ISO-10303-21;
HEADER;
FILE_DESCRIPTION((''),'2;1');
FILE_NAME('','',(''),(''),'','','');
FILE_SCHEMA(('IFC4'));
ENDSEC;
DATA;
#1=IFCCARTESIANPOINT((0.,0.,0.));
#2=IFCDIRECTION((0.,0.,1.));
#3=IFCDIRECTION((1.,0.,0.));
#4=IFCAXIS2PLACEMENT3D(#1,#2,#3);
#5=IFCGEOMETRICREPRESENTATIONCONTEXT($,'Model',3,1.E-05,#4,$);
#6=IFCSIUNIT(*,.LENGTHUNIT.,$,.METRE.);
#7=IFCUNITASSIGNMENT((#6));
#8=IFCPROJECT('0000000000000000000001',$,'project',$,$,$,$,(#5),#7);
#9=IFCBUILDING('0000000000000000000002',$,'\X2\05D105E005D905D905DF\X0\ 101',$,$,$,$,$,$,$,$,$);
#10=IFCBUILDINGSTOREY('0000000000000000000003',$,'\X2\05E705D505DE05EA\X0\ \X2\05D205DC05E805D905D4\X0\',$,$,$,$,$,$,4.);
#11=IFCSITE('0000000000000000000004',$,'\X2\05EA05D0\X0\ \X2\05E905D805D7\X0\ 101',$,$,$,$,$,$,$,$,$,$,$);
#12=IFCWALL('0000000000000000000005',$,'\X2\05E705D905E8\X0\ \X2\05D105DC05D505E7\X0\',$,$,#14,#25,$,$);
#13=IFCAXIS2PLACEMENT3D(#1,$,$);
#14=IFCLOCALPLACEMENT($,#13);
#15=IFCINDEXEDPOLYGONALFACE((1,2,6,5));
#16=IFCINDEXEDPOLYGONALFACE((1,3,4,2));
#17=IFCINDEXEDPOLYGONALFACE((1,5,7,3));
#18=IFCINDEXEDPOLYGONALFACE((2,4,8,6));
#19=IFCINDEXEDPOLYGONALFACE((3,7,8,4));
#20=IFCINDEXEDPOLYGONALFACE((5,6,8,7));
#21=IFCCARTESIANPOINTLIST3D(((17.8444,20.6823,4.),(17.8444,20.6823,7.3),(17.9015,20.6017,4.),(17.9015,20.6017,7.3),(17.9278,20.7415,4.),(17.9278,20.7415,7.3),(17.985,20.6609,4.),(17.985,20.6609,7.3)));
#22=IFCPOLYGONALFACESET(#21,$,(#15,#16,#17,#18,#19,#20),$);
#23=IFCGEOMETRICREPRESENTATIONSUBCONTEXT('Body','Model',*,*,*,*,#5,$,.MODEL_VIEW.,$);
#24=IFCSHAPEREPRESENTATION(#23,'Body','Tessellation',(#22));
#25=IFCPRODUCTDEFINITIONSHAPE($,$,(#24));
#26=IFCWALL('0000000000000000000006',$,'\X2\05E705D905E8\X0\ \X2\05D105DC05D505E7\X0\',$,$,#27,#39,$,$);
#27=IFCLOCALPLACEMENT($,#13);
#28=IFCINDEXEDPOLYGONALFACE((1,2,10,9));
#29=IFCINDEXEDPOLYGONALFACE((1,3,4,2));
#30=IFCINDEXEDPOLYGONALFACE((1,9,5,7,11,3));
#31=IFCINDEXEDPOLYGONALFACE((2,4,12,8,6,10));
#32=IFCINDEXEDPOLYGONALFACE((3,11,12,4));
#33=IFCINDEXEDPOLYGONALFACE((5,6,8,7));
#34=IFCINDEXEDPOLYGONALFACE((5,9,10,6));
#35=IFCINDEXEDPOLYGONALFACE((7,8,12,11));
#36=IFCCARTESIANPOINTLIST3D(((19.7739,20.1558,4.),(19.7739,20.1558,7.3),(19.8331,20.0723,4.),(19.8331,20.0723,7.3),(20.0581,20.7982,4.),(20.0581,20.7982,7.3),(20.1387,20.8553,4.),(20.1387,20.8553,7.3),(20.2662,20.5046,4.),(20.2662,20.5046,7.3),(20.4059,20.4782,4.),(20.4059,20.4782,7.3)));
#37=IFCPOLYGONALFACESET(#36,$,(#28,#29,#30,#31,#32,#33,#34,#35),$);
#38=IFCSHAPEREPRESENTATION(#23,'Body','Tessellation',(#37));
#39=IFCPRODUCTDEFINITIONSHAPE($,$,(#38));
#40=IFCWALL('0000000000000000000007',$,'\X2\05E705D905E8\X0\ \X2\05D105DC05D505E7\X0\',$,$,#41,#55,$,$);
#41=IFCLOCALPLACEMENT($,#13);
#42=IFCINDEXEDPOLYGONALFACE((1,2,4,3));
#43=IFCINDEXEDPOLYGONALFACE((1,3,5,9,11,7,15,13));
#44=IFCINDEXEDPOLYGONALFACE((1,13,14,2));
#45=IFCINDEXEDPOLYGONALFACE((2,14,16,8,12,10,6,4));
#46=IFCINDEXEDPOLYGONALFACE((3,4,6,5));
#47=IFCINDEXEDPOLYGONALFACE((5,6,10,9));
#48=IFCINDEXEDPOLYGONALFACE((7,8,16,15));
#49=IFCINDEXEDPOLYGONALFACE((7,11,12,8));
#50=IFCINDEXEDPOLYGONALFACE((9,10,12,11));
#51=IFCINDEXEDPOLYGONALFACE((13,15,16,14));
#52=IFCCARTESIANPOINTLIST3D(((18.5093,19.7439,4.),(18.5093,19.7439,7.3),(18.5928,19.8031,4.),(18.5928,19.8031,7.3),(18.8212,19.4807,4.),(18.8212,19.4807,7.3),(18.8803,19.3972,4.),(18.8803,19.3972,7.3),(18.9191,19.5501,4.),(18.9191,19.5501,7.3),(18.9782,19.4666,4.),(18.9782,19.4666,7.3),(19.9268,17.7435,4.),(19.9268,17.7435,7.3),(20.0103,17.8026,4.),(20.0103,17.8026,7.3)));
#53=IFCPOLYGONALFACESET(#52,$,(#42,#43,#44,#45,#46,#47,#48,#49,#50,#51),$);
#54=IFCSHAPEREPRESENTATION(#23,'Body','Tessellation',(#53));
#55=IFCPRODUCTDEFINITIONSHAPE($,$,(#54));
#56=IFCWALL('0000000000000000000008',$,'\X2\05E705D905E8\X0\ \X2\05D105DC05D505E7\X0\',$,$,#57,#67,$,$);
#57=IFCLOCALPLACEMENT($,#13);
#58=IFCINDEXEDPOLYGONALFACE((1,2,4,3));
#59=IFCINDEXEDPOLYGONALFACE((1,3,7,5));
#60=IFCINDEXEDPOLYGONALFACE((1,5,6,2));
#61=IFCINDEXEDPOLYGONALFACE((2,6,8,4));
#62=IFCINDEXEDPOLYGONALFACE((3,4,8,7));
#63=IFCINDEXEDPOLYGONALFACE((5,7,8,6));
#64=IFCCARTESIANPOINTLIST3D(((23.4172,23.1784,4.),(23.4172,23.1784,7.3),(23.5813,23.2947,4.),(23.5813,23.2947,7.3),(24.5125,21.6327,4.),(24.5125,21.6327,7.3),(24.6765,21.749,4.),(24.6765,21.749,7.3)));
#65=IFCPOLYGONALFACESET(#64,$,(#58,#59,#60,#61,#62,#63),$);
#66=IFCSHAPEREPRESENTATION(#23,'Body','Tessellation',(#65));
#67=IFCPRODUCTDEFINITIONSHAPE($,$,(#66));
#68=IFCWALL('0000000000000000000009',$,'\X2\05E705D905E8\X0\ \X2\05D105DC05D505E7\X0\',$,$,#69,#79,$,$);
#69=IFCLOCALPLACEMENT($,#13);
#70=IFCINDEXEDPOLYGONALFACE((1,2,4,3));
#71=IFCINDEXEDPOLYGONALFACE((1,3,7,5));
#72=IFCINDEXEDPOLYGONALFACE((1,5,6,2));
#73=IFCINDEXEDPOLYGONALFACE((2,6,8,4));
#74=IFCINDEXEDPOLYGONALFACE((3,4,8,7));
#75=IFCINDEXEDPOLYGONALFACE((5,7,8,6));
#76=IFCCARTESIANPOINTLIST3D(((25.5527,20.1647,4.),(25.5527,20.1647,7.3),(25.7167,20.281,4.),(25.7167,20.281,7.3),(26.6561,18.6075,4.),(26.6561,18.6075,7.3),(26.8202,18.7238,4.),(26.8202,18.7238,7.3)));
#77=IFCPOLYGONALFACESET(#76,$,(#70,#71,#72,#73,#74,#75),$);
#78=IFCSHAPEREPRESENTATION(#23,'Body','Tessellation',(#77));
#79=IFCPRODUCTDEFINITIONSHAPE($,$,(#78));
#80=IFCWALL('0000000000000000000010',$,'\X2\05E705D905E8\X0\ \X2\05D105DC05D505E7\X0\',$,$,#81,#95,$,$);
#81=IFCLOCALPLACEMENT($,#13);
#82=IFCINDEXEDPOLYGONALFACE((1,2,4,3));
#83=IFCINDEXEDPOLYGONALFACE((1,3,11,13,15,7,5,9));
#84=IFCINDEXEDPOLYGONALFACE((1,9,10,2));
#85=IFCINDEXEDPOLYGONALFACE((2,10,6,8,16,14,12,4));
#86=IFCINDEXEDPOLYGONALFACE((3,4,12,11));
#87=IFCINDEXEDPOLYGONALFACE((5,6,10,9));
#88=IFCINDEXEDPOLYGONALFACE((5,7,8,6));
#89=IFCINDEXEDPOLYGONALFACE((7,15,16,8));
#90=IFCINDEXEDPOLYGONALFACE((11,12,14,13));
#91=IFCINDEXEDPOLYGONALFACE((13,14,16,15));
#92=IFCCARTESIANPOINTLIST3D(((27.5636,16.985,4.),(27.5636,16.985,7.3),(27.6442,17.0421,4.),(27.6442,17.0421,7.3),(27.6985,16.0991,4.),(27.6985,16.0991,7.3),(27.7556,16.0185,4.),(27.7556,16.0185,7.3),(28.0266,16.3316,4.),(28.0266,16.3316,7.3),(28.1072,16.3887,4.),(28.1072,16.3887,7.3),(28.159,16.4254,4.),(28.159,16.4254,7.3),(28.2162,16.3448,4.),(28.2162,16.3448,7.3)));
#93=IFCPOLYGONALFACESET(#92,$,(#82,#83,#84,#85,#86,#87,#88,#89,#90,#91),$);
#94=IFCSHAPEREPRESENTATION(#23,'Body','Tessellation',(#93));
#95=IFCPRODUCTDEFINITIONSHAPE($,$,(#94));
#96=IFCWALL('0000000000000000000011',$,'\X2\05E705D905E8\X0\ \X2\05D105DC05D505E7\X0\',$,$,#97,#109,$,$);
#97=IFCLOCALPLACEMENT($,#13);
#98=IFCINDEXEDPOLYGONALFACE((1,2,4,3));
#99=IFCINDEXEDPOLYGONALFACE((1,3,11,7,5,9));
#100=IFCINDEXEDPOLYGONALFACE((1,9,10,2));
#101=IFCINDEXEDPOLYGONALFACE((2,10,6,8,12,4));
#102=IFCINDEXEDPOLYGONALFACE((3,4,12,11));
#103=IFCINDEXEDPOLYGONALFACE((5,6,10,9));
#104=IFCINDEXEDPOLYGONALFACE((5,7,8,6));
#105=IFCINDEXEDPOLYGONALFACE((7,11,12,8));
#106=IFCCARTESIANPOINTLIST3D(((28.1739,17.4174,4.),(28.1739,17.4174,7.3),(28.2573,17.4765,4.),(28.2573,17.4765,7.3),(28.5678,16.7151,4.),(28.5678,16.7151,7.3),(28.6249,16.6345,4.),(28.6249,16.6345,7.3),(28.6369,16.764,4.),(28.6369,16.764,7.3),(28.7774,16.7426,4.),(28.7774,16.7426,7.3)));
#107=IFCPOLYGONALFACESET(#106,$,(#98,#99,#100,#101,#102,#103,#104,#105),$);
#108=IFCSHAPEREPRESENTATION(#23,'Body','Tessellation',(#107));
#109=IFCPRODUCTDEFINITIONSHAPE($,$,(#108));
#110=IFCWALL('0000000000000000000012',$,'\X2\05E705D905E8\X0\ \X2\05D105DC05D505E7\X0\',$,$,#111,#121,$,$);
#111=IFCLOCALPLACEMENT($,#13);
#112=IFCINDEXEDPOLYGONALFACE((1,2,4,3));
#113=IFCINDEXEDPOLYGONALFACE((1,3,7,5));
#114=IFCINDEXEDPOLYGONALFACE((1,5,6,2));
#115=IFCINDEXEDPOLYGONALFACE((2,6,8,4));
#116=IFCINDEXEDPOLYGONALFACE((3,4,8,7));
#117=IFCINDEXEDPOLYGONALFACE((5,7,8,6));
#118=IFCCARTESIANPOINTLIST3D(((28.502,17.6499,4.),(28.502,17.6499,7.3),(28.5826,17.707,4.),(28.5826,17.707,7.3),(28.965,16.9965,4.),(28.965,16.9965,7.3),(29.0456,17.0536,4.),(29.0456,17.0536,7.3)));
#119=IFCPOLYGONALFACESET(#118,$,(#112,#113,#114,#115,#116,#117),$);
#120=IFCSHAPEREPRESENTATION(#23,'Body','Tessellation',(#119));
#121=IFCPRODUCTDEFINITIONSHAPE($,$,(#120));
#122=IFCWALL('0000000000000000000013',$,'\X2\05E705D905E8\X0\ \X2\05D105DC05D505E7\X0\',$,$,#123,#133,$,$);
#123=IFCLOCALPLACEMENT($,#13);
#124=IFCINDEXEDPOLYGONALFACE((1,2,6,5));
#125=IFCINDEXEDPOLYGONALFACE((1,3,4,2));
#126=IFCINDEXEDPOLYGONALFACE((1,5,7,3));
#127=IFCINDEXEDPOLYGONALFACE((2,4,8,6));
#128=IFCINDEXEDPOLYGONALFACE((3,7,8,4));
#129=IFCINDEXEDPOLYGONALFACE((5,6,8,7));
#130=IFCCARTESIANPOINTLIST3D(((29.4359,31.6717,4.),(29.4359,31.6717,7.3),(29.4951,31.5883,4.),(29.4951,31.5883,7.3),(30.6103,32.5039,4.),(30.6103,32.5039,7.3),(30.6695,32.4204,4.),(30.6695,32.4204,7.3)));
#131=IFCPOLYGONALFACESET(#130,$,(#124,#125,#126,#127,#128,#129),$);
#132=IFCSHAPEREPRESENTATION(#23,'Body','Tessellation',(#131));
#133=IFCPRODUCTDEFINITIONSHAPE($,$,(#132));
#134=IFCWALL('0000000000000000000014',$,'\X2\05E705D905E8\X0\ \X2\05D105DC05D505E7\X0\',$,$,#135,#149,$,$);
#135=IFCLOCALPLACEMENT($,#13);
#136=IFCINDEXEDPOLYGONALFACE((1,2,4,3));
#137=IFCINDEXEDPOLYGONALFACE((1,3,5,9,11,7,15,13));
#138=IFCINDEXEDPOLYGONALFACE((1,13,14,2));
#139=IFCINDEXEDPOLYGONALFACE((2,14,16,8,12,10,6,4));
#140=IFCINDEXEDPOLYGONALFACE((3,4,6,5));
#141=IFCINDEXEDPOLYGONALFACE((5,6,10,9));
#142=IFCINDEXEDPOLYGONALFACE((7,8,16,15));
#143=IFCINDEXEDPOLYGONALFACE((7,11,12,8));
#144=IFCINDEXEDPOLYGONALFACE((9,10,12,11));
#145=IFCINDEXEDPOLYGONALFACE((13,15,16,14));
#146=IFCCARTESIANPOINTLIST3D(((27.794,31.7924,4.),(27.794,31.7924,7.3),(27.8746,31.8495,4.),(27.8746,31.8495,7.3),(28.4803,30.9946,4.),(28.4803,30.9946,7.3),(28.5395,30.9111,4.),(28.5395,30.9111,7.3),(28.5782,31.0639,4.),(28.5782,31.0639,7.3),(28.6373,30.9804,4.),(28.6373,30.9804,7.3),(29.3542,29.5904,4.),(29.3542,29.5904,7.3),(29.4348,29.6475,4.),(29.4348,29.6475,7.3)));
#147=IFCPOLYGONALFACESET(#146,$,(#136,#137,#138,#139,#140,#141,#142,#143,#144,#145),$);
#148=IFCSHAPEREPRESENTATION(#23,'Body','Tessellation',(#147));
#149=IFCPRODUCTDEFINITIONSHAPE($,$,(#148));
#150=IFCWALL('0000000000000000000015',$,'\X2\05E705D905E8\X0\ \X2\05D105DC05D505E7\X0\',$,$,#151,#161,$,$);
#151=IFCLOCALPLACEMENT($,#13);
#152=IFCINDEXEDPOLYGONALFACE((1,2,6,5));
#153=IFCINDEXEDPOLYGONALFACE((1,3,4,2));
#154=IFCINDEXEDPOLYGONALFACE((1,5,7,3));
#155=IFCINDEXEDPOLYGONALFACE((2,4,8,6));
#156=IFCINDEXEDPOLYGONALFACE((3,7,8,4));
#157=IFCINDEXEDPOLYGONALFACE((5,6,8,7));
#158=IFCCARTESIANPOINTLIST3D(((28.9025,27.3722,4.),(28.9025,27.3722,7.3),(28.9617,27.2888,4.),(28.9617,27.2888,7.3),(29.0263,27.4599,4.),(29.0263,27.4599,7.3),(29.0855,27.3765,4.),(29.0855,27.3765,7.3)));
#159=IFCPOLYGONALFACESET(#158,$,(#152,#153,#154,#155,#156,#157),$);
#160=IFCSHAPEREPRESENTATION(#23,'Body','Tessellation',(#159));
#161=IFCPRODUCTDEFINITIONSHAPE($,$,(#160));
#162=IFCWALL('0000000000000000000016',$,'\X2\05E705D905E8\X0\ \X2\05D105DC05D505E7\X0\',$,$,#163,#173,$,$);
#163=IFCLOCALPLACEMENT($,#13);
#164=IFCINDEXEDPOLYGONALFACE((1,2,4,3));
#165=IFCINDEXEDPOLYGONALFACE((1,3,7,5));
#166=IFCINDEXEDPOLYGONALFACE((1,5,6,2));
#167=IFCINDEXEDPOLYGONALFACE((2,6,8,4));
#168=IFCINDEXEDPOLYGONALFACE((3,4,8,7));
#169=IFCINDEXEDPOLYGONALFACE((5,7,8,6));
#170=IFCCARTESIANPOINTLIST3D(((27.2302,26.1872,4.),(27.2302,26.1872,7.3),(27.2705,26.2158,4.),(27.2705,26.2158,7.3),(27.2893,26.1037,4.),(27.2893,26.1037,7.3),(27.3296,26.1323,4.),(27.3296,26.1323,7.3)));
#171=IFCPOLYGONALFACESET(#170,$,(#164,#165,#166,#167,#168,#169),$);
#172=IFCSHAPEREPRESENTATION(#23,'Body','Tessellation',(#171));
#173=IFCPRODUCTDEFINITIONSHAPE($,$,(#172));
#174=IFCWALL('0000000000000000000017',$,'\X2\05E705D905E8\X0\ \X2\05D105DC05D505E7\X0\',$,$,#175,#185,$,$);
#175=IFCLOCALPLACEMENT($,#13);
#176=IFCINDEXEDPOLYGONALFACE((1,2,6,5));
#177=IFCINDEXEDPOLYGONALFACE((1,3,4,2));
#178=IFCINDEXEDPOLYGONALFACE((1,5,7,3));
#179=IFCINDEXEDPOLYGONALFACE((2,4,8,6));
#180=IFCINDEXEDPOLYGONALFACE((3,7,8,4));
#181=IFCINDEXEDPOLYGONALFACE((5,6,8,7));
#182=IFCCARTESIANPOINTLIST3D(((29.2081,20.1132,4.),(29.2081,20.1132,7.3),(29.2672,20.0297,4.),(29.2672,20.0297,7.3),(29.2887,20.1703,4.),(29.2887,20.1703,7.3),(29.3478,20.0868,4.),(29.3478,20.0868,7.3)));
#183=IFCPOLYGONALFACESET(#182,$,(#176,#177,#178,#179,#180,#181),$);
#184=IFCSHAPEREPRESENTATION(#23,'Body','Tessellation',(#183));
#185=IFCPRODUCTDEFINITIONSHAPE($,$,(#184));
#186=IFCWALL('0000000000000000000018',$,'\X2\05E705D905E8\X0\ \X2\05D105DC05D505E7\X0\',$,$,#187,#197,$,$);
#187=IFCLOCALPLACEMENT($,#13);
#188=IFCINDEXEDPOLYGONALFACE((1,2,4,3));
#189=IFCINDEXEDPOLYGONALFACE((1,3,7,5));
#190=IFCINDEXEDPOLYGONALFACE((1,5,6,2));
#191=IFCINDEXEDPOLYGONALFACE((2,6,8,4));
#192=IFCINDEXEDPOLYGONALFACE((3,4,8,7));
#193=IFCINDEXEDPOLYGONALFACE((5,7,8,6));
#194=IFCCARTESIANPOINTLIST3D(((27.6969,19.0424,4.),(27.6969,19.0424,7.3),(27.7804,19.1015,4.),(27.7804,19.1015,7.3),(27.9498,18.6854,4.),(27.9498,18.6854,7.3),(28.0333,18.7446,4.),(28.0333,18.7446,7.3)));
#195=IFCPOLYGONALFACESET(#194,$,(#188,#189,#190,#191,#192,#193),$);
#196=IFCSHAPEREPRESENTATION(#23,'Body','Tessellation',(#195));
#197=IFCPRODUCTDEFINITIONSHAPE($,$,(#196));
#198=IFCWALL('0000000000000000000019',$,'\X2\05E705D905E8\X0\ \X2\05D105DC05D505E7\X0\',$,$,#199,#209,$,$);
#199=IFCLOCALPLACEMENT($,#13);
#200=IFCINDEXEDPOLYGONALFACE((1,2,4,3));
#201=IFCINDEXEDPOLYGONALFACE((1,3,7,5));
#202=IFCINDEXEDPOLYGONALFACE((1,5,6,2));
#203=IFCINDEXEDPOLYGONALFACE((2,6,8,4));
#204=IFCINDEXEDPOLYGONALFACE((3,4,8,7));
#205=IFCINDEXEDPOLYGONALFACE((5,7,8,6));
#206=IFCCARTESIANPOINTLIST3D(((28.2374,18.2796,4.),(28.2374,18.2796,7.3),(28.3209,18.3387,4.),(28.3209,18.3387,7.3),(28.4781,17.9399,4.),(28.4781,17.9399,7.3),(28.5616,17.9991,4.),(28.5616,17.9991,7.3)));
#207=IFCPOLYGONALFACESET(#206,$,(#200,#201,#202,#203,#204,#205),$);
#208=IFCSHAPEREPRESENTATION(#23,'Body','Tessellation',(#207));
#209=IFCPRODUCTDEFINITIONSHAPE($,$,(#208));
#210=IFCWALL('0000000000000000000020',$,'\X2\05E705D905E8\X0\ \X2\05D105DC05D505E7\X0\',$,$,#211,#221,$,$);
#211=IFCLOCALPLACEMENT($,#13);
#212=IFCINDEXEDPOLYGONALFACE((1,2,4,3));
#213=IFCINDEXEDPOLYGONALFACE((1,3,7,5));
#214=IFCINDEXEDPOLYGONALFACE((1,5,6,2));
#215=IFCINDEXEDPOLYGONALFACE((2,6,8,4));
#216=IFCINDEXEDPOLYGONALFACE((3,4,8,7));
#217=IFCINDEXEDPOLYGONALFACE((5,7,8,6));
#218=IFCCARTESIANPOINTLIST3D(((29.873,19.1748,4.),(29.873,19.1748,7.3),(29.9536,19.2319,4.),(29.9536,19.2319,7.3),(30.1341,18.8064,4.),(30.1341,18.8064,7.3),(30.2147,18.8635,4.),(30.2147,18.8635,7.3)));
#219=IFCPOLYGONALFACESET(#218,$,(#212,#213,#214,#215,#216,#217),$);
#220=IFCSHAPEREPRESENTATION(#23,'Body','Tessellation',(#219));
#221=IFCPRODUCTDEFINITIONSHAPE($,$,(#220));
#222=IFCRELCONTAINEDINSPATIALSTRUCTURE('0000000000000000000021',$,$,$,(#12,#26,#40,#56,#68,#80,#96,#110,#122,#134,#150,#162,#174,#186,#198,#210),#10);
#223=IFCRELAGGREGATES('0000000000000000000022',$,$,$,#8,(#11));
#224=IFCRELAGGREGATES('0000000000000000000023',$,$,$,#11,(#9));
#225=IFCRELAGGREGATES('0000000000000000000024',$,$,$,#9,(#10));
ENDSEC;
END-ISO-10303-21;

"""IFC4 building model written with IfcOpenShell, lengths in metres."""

from ifc_helpers import new_model, si_unit, frame, origin_with_axes, context, subcontext, project, spatial, polyline, outline, extrude, element, save


model = new_model("IFC4")

# Units and contexts
model_context = context("Model", 3, precision=1e-05, world=origin_with_axes())
body_context = subcontext(model_context, "Body", "Model", "MODEL_VIEW")
ifc_project = project(units=[si_unit("LENGTHUNIT", "METRE")], contexts=[model_context])

# Site, building, storey
site = spatial("IfcSite", under=ifc_project, Name="תא שטח 101")
building = spatial("IfcBuilding", under=site, Name="בניין 101")
storey = spatial("IfcBuildingStorey", under=building, Name="קומת גלריה", Elevation=4.0)

# Walls
element("IfcWall", 1, inside=storey, Name="קיר בלוק", context=body_context, shape_type="SweptSolid", body=[
    extrude(outline(polyline([(17.985, 20.6609), (17.9278, 20.7415), (17.8444, 20.6823), (17.9015, 20.6017), (17.985, 20.6609)])), frame((0.0, 0.0, 4.0)), (0.0, 0.0, 1.0), 3.3),
])
element("IfcWall", 2, inside=storey, Name="קיר בלוק", context=body_context, shape_type="SweptSolid", body=[
    extrude(outline(polyline([(19.8331, 20.0723), (20.4059, 20.4782), (20.1387, 20.8553), (20.0581, 20.7982), (20.2662, 20.5046), (19.7739, 20.1558), (19.8331, 20.0723)])), frame((0.0, 0.0, 4.0)), (0.0, 0.0, 1.0), 3.3),
])
element("IfcWall", 3, inside=storey, Name="קיר בלוק", context=body_context, shape_type="SweptSolid", body=[
    extrude(outline(polyline([(18.5093, 19.7439), (19.9268, 17.7435), (20.0103, 17.8026), (18.8803, 19.3972), (18.9782, 19.4666), (18.9191, 19.5501), (18.8212, 19.4807), (18.5928, 19.8031), (18.5093, 19.7439)])), frame((0.0, 0.0, 4.0)), (0.0, 0.0, 1.0), 3.3),
])
element("IfcWall", 4, inside=storey, Name="קיר בלוק", context=body_context, shape_type="SweptSolid", body=[
    extrude(outline(polyline([(23.5813, 23.2947), (23.4172, 23.1784), (24.5125, 21.6327), (24.6765, 21.749), (23.5813, 23.2947)])), frame((0.0, 0.0, 4.0)), (0.0, 0.0, 1.0), 3.3),
])
element("IfcWall", 5, inside=storey, Name="קיר בלוק", context=body_context, shape_type="SweptSolid", body=[
    extrude(outline(polyline([(25.7167, 20.281), (25.5527, 20.1647), (26.6561, 18.6075), (26.8202, 18.7238), (25.7167, 20.281)])), frame((0.0, 0.0, 4.0)), (0.0, 0.0, 1.0), 3.3),
])
element("IfcWall", 6, inside=storey, Name="קיר בלוק", context=body_context, shape_type="SweptSolid", body=[
    extrude(outline(polyline([(27.5636, 16.985), (28.0266, 16.3316), (27.6985, 16.0991), (27.7556, 16.0185), (28.2162, 16.3448), (28.159, 16.4254), (28.1072, 16.3887), (27.6442, 17.0421), (27.5636, 16.985)])), frame((0.0, 0.0, 4.0)), (0.0, 0.0, 1.0), 3.3),
])
element("IfcWall", 7, inside=storey, Name="קיר בלוק", context=body_context, shape_type="SweptSolid", body=[
    extrude(outline(polyline([(28.5678, 16.7151), (28.6249, 16.6345), (28.7774, 16.7426), (28.2573, 17.4765), (28.1739, 17.4174), (28.6369, 16.764), (28.5678, 16.7151)])), frame((0.0, 0.0, 4.0)), (0.0, 0.0, 1.0), 3.3),
])
element("IfcWall", 8, inside=storey, Name="קיר בלוק", context=body_context, shape_type="SweptSolid", body=[
    extrude(outline(polyline([(28.965, 16.9965), (29.0456, 17.0536), (28.5826, 17.707), (28.502, 17.6499), (28.965, 16.9965)])), frame((0.0, 0.0, 4.0)), (0.0, 0.0, 1.0), 3.3),
])
element("IfcWall", 9, inside=storey, Name="קיר בלוק", context=body_context, shape_type="SweptSolid", body=[
    extrude(outline(polyline([(29.4951, 31.5883), (30.6695, 32.4204), (30.6103, 32.5039), (29.4359, 31.6717), (29.4951, 31.5883)])), frame((0.0, 0.0, 4.0)), (0.0, 0.0, 1.0), 3.3),
])
element("IfcWall", 10, inside=storey, Name="קיר בלוק", context=body_context, shape_type="SweptSolid", body=[
    extrude(outline(polyline([(27.794, 31.7924), (29.3542, 29.5904), (29.4348, 29.6475), (28.5395, 30.9111), (28.6373, 30.9804), (28.5782, 31.0639), (28.4803, 30.9946), (27.8746, 31.8495), (27.794, 31.7924)])), frame((0.0, 0.0, 4.0)), (0.0, 0.0, 1.0), 3.3),
])
element("IfcWall", 11, inside=storey, Name="קיר בלוק", context=body_context, shape_type="SweptSolid", body=[
    extrude(outline(polyline([(28.9617, 27.2888), (29.0855, 27.3765), (29.0263, 27.4599), (28.9025, 27.3722), (28.9617, 27.2888)])), frame((0.0, 0.0, 4.0)), (0.0, 0.0, 1.0), 3.3),
])
element("IfcWall", 12, inside=storey, Name="קיר בלוק", context=body_context, shape_type="SweptSolid", body=[
    extrude(outline(polyline([(27.2893, 26.1037), (27.3296, 26.1323), (27.2705, 26.2158), (27.2302, 26.1872), (27.2893, 26.1037)])), frame((0.0, 0.0, 4.0)), (0.0, 0.0, 1.0), 3.3),
])
element("IfcWall", 13, inside=storey, Name="קיר בלוק", context=body_context, shape_type="SweptSolid", body=[
    extrude(outline(polyline([(29.2887, 20.1703), (29.2081, 20.1132), (29.2672, 20.0297), (29.3478, 20.0868), (29.2887, 20.1703)])), frame((0.0, 0.0, 4.0)), (0.0, 0.0, 1.0), 3.3),
])
element("IfcWall", 14, inside=storey, Name="קיר בלוק", context=body_context, shape_type="SweptSolid", body=[
    extrude(outline(polyline([(27.9498, 18.6854), (28.0333, 18.7446), (27.7804, 19.1015), (27.6969, 19.0424), (27.9498, 18.6854)])), frame((0.0, 0.0, 4.0)), (0.0, 0.0, 1.0), 3.3),
])
element("IfcWall", 15, inside=storey, Name="קיר בלוק", context=body_context, shape_type="SweptSolid", body=[
    extrude(outline(polyline([(28.5616, 17.9991), (28.3209, 18.3387), (28.2374, 18.2796), (28.4781, 17.9399), (28.5616, 17.9991)])), frame((0.0, 0.0, 4.0)), (0.0, 0.0, 1.0), 3.3),
])
element("IfcWall", 16, inside=storey, Name="קיר בלוק", context=body_context, shape_type="SweptSolid", body=[
    extrude(outline(polyline([(30.2147, 18.8635), (29.9536, 19.2319), (29.873, 19.1748), (30.1341, 18.8064), (30.2147, 18.8635)])), frame((0.0, 0.0, 4.0)), (0.0, 0.0, 1.0), 3.3),
])

save(model, "model.ifc")
